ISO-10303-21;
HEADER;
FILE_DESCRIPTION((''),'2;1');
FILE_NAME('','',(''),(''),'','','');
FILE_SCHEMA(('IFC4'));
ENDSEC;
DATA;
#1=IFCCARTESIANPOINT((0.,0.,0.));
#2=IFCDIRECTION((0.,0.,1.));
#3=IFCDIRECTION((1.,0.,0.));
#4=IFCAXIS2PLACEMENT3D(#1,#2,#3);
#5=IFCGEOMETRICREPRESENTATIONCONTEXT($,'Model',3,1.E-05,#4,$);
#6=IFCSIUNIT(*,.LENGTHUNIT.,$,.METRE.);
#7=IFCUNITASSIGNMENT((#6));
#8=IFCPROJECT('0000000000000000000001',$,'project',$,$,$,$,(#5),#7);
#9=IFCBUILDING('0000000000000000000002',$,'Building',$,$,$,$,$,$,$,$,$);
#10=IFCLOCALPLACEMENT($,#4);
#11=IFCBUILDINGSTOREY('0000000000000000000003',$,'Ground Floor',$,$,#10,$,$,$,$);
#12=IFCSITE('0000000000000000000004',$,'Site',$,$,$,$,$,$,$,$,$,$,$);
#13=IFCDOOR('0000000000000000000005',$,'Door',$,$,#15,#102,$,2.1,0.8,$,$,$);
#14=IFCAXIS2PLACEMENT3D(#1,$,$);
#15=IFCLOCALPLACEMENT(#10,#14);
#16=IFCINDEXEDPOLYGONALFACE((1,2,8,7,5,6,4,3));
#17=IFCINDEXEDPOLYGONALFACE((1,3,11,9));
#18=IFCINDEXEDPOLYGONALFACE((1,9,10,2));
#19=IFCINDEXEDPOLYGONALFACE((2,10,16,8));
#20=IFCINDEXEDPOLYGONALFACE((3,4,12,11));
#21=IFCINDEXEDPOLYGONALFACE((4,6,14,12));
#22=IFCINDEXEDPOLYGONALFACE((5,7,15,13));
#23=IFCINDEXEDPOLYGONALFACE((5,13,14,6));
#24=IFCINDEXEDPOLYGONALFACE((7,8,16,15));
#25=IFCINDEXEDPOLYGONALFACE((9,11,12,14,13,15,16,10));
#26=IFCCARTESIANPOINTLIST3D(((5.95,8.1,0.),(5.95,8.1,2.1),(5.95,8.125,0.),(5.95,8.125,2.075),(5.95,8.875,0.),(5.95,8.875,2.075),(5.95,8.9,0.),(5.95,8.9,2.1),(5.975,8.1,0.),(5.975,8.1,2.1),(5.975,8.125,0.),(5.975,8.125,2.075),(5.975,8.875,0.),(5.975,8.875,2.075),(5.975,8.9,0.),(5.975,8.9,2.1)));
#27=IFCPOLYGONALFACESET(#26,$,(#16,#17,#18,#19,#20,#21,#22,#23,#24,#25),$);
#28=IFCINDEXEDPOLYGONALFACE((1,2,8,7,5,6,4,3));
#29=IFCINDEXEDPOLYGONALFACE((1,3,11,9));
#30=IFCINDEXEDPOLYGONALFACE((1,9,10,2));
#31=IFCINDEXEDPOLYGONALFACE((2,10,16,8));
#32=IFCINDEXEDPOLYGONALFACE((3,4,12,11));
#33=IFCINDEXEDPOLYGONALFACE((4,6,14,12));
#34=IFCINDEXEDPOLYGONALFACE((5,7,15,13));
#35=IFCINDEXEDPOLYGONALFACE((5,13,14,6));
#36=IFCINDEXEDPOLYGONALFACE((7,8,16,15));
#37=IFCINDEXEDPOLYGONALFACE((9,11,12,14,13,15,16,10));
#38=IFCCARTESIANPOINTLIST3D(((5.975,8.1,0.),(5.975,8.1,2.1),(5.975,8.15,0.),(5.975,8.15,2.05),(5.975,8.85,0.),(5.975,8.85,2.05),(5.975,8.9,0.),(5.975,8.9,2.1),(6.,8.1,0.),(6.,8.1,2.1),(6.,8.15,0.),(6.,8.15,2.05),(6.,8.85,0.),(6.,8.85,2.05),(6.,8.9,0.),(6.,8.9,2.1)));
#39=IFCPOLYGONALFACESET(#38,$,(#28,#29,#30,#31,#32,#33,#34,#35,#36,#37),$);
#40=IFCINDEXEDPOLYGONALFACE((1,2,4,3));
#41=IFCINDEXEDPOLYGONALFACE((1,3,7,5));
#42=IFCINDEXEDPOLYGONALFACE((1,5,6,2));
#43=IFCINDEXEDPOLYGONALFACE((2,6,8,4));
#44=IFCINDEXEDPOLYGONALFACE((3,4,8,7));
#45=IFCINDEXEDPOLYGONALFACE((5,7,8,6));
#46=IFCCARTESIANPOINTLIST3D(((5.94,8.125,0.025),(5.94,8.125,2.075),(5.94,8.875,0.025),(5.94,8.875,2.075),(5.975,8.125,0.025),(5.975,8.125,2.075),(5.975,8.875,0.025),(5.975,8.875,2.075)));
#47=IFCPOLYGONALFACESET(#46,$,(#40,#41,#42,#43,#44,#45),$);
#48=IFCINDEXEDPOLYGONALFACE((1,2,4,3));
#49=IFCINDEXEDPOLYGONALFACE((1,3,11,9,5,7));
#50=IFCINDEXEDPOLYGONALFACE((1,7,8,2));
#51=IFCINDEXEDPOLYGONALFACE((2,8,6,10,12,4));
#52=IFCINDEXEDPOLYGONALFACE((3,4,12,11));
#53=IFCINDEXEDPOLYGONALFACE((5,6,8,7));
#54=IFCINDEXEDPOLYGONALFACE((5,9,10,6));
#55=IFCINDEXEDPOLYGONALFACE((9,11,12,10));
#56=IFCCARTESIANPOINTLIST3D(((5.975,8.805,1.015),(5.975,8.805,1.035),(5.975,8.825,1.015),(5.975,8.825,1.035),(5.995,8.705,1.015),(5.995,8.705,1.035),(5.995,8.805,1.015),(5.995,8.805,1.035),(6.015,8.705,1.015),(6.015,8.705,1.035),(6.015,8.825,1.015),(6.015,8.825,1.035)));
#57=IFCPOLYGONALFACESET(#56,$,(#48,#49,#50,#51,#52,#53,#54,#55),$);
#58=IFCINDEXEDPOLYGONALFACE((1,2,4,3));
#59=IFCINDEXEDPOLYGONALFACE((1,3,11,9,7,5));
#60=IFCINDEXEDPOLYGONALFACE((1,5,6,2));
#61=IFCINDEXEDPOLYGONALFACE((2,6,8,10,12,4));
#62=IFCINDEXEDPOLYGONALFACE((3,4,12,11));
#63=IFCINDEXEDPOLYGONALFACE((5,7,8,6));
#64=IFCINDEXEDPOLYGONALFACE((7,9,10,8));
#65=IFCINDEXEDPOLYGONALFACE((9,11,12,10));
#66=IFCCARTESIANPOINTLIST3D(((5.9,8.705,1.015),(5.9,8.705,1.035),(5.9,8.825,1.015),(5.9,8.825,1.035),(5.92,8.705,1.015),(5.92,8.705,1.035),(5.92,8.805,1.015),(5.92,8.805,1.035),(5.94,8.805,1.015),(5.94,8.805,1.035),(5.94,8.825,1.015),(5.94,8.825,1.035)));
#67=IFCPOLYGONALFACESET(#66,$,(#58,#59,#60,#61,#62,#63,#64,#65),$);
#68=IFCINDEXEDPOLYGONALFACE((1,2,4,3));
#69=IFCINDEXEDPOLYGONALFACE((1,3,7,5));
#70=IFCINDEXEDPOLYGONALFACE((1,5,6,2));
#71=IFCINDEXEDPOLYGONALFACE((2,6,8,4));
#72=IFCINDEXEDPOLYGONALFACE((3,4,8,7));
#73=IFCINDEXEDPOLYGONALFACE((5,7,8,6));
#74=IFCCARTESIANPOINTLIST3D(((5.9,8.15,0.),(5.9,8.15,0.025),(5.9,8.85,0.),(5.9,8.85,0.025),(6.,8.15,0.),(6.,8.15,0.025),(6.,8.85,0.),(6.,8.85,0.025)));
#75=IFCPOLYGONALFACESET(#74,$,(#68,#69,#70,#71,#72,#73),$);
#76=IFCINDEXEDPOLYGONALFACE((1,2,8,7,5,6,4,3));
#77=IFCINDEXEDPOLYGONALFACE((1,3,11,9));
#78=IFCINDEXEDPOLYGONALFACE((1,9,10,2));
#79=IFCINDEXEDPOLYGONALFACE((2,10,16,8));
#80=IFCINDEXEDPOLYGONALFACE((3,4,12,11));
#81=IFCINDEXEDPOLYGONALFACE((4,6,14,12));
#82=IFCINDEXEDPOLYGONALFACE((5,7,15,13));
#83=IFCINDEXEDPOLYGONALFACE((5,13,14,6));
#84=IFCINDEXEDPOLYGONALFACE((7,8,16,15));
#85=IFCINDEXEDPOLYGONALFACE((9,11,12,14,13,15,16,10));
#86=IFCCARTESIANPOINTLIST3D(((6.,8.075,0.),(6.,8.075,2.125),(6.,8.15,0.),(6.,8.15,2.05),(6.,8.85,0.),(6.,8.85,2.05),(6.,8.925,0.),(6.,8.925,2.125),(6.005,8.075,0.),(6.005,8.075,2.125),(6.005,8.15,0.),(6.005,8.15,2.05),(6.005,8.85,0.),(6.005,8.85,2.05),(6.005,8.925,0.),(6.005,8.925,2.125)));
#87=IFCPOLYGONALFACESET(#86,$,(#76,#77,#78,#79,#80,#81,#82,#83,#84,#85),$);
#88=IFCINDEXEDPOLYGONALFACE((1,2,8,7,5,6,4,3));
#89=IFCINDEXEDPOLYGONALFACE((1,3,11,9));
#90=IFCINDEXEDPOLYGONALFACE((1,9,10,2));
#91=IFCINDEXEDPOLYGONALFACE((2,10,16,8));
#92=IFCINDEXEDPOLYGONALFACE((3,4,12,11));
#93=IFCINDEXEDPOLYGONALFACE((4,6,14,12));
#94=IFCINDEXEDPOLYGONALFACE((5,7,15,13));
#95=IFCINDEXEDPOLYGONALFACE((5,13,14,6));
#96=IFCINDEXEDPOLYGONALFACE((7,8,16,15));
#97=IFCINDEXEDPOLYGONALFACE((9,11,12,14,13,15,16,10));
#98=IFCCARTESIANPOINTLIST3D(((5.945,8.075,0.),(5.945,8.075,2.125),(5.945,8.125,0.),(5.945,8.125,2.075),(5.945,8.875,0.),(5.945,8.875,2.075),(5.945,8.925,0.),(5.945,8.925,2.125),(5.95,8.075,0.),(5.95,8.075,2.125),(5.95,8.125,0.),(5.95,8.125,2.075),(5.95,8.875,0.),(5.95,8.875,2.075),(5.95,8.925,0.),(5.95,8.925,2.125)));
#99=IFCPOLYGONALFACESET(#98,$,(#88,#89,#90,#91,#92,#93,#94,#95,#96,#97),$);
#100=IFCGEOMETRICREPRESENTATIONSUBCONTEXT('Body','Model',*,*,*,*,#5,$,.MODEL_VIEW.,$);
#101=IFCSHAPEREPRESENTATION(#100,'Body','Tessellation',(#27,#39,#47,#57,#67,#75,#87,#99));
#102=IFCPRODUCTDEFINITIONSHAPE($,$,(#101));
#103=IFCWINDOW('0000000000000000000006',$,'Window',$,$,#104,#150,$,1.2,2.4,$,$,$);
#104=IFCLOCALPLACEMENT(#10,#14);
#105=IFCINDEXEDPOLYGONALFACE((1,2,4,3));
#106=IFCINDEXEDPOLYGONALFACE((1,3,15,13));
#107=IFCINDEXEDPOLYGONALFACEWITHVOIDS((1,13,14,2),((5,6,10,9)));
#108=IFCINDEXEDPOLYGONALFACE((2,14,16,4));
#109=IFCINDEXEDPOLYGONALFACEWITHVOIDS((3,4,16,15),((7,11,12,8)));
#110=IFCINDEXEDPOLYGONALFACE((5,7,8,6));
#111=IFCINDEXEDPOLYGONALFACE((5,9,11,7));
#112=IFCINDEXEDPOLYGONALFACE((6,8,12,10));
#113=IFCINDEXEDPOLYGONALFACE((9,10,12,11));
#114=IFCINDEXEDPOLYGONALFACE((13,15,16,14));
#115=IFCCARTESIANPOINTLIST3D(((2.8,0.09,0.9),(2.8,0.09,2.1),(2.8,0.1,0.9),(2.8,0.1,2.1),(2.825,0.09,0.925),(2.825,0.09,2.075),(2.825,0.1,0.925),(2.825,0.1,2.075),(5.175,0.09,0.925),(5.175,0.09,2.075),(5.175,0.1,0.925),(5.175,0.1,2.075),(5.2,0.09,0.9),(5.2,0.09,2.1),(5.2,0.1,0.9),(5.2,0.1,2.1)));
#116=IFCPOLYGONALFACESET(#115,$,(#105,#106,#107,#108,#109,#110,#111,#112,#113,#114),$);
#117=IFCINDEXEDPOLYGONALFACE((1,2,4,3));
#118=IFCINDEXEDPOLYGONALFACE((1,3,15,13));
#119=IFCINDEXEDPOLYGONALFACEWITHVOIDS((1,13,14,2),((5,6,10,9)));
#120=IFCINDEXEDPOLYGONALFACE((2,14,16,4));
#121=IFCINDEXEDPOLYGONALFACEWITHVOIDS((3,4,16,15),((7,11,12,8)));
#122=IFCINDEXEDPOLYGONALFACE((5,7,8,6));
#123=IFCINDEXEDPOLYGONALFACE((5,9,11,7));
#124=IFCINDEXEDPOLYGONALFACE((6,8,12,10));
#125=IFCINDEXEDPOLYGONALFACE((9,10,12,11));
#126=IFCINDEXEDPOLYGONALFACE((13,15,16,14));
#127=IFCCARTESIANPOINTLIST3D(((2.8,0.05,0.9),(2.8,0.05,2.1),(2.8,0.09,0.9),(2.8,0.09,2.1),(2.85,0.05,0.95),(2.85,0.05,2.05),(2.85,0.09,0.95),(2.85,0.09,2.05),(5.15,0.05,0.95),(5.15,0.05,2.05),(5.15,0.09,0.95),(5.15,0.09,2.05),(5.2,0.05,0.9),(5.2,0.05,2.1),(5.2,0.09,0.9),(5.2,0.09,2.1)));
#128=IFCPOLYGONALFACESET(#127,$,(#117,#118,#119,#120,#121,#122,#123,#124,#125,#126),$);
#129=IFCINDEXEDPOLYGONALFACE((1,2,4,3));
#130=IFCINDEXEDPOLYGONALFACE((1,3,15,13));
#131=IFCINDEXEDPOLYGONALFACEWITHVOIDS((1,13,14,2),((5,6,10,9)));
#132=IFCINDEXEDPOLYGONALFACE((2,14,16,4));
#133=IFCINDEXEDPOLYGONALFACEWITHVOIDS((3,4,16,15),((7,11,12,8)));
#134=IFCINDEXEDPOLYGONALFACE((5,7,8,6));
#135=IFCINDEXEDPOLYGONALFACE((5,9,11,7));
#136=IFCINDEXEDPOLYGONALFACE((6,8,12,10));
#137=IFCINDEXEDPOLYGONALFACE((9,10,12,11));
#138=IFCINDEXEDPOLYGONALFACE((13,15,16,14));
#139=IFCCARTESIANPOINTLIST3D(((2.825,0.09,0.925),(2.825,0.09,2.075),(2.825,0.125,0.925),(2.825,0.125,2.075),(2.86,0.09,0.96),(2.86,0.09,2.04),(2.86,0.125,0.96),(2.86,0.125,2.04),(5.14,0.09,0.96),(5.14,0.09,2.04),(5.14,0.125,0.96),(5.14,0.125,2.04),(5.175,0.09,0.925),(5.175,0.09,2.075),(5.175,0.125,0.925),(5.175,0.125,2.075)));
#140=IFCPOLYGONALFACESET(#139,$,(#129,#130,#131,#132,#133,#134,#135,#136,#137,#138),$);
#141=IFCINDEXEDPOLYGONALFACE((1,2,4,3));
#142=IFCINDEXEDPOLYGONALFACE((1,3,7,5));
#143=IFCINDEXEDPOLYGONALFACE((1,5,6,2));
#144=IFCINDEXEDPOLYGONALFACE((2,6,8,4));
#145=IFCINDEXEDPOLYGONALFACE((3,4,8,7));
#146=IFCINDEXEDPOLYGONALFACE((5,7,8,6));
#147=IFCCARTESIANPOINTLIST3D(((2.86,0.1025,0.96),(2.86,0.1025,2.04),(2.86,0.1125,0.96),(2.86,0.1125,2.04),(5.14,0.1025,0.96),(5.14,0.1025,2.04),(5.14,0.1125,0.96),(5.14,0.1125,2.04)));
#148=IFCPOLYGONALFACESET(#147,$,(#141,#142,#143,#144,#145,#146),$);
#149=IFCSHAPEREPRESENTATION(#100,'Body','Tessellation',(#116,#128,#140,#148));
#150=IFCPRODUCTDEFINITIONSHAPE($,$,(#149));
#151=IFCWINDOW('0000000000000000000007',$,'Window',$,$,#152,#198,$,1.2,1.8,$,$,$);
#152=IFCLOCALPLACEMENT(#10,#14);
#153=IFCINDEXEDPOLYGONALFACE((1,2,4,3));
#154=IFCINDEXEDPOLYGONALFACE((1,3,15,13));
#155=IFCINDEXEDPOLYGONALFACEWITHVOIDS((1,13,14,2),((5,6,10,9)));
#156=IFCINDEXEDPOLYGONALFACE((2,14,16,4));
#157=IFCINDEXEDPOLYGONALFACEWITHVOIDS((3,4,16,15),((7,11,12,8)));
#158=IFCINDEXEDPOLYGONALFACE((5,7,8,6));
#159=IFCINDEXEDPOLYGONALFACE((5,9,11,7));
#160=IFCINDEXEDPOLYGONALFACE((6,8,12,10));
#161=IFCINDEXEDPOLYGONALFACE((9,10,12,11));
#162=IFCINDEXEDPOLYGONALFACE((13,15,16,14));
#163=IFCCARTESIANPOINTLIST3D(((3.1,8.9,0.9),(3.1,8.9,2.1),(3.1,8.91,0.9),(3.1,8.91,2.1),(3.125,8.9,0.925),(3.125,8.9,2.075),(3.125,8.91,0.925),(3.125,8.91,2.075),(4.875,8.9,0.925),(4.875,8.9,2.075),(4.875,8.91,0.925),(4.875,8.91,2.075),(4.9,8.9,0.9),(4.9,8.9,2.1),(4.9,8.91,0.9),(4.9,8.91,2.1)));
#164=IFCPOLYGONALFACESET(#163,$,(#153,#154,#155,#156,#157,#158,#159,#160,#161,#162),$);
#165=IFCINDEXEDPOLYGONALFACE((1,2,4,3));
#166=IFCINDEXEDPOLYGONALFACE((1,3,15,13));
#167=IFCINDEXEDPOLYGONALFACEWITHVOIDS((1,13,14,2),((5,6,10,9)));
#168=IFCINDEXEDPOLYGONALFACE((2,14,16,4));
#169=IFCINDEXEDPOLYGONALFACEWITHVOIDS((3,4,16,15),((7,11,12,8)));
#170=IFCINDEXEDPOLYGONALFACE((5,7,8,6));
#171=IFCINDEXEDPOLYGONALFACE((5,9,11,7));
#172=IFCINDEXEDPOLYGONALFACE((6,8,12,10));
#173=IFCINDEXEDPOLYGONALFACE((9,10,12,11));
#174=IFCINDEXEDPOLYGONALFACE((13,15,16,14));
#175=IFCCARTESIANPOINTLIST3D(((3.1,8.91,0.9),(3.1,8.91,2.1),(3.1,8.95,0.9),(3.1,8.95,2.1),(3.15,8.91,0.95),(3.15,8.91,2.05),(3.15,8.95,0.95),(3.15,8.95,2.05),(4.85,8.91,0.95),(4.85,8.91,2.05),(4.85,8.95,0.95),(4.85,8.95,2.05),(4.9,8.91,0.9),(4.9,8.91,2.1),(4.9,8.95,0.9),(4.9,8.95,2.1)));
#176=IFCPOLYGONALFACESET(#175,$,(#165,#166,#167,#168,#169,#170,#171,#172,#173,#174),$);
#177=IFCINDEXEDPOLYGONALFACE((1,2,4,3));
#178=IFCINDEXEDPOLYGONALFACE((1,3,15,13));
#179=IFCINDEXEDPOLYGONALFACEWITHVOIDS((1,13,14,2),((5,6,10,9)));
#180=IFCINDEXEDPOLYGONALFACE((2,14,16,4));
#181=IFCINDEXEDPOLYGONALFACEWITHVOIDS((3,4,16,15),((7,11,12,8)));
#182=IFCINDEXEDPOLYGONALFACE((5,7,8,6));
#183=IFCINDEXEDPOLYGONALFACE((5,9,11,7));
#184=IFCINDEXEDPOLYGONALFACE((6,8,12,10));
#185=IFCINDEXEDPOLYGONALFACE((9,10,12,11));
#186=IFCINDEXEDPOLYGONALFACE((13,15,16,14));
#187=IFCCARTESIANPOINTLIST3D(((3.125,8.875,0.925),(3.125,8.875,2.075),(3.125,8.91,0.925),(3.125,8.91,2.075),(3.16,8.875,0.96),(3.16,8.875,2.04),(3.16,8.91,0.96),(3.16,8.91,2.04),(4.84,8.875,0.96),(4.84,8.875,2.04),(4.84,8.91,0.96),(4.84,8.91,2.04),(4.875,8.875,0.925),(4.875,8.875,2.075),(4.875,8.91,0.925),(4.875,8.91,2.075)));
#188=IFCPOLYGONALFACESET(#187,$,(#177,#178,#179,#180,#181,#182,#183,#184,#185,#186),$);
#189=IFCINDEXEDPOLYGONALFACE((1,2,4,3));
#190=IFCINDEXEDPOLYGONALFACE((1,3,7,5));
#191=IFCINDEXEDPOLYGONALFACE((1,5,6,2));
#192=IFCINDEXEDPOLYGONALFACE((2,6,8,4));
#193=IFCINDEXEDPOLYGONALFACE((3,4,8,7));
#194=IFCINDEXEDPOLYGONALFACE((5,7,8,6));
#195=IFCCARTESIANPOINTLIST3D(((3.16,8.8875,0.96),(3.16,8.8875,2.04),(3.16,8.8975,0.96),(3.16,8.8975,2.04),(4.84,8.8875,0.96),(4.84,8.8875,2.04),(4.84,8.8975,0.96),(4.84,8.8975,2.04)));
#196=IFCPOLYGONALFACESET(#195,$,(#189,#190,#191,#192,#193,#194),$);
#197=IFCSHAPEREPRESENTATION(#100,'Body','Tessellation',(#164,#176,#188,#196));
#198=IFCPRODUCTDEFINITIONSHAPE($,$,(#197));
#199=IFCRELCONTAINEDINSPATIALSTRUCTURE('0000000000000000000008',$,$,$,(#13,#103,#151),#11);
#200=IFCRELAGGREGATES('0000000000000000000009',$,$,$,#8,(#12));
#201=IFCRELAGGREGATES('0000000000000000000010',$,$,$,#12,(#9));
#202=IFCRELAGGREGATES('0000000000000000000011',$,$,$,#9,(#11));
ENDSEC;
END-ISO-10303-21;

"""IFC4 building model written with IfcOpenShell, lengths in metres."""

from ifc_helpers import new_model, si_unit, frame, origin_with_axes, place, context, subcontext, project, spatial, line, indexed_curve, outline, extrude, element, save


model = new_model("IFC4")

# Units and contexts
model_context = context("Model", 3, precision=1e-05, world=origin_with_axes())
body_context = subcontext(model_context, "Body", "Model", "MODEL_VIEW")
ifc_project = project(units=[si_unit("LENGTHUNIT", "METRE")], contexts=[model_context])

# Site, building, storey
site = spatial("IfcSite", under=ifc_project, Name="Site")
building = spatial("IfcBuilding", under=site, Name="Building")
storey_placement = place(None, origin_with_axes())
storey = spatial("IfcBuildingStorey", under=building, at=storey_placement, Name="Ground Floor")

# Door
door_1_placement = place(storey_placement, frame((6.0, 8.1, 0.0), z_axis=(0.0, 0.0, 1.0), x_axis=(0.0, 1.0, 0.0)))
element("IfcDoor", 1, at=door_1_placement, inside=storey, Name="Door", OverallHeight=2.1, OverallWidth=0.8, context=body_context, shape_type="SweptSolid", body=[
    extrude(outline(indexed_curve([(0.0, 0.0), (0.0, 2.1), (0.8, 2.1), (0.8, 0.0), (0.775, 0.0), (0.775, 2.075), (0.025, 2.075), (0.025, 0.0)], segments=[line(1, 2, 3, 4, 5, 6, 7, 8, 1)])), frame((0.0, 0.025, 0.0), z_axis=(0.0, -1.0, 0.0), x_axis=(1.0, 0.0, 0.0)), (0.0, 0.0, -1.0), 0.025),
    extrude(outline(indexed_curve([(0.0, 0.0), (0.0, 2.1), (0.8, 2.1), (0.8, 0.0), (0.75, 0.0), (0.75, 2.05), (0.05, 2.05), (0.05, 0.0)], segments=[line(1, 2, 3, 4, 5, 6, 7, 8, 1)])), frame((0.0, 0.0, 0.0), z_axis=(0.0, -1.0, 0.0), x_axis=(1.0, 0.0, 0.0)), (0.0, 0.0, -1.0), 0.025),
    extrude(outline(indexed_curve([(0.0, 0.0), (0.75, 0.0), (0.75, 0.035), (0.0, 0.035)], segments=[line(1, 2, 3, 4, 1)])), frame((0.025, 0.025, 0.025), z_axis=(0.0, 0.0, 1.0), x_axis=(1.0, 0.0, 0.0)), (0.0, 0.0, 1.0), 2.05),
    extrude(outline(indexed_curve([(0.0, 0.0), (0.0, -0.04), (-0.12, -0.04), (-0.12, -0.02), (-0.02, -0.02), (-0.02, 0.0)], segments=[line(1, 2, 3, 4, 5, 6, 1)])), frame((0.725, 0.025, 1.015), z_axis=(0.0, 0.0, 1.0), x_axis=(1.0, 0.0, 0.0)), (0.0, 0.0, 1.0), 0.02),
    extrude(outline(indexed_curve([(0.0, 0.0), (0.0, 0.04), (-0.12, 0.04), (-0.12, 0.02), (-0.02, 0.02), (-0.02, 0.0)], segments=[line(1, 2, 3, 4, 5, 6, 1)])), frame((0.725, 0.06, 1.015), z_axis=(0.0, 0.0, 1.0), x_axis=(1.0, 0.0, 0.0)), (0.0, 0.0, 1.0), 0.02),
    extrude(outline(indexed_curve([(0.0, 0.0), (0.7, 0.0), (0.7, 0.1), (0.0, 0.1)], segments=[line(1, 2, 3, 4, 1)])), frame((0.05, 0.0, 0.0), z_axis=(0.0, 0.0, 1.0), x_axis=(1.0, 0.0, 0.0)), (0.0, 0.0, 1.0), 0.025),
    extrude(outline(indexed_curve([(0.0, 0.0), (0.0, 2.125), (0.85, 2.125), (0.85, 0.0), (0.775, 0.0), (0.775, 2.05), (0.075, 2.05), (0.075, 0.0)], segments=[line(1, 2, 3, 4, 5, 6, 7, 8, 1)])), frame((-0.025, -0.005, 0.0), z_axis=(0.0, -1.0, 0.0), x_axis=(1.0, 0.0, 0.0)), (0.0, 0.0, -1.0), 0.005),
    extrude(outline(indexed_curve([(0.0, 0.0), (0.0, 2.125), (0.85, 2.125), (0.85, 0.0), (0.8, 0.0), (0.8, 2.075), (0.05, 2.075), (0.05, 0.0)], segments=[line(1, 2, 3, 4, 5, 6, 7, 8, 1)])), frame((-0.025, 0.05, 0.0), z_axis=(0.0, -1.0, 0.0), x_axis=(1.0, 0.0, 0.0)), (0.0, 0.0, -1.0), 0.005),
])

# Windows
window_1_placement = place(storey_placement, frame((2.8, 0.0, 0.9), z_axis=(0.0, 0.0, 1.0), x_axis=(1.0, 0.0, 0.0)))
element("IfcWindow", 2, at=window_1_placement, inside=storey, Name="Window", OverallHeight=1.2, OverallWidth=2.4, context=body_context, shape_type="SweptSolid", body=[
    extrude(outline(indexed_curve([(0.0, 0.0), (2.4, 0.0), (2.4, 1.2), (0.0, 1.2)], segments=[line(1, 2, 3, 4, 1)]), holes=[indexed_curve([(0.025, 0.025), (2.375, 0.025), (2.375, 1.175), (0.025, 1.175)], segments=[line(1, 2, 3, 4, 1)])]), frame((0.0, 0.09, 0.0), z_axis=(0.0, -1.0, 0.0), x_axis=(1.0, 0.0, 0.0)), (0.0, 0.0, -1.0), 0.01),
    extrude(outline(indexed_curve([(0.0, 0.0), (2.4, 0.0), (2.4, 1.2), (0.0, 1.2)], segments=[line(1, 2, 3, 4, 1)]), holes=[indexed_curve([(0.05, 0.05), (2.35, 0.05), (2.35, 1.15), (0.05, 1.15)], segments=[line(1, 2, 3, 4, 1)])]), frame((0.0, 0.05, 0.0), z_axis=(0.0, -1.0, 0.0), x_axis=(1.0, 0.0, 0.0)), (0.0, 0.0, -1.0), 0.04),
    extrude(outline(indexed_curve([(0.0, 0.0), (2.35, 0.0), (2.35, 1.15), (0.0, 1.15)], segments=[line(1, 2, 3, 4, 1)]), holes=[indexed_curve([(0.035, 0.035), (2.315, 0.035), (2.315, 1.115), (0.035, 1.115)], segments=[line(1, 2, 3, 4, 1)])]), frame((0.025, 0.09, 0.025), z_axis=(0.0, -1.0, 0.0), x_axis=(1.0, 0.0, 0.0)), (0.0, 0.0, -1.0), 0.035),
    extrude(outline(indexed_curve([(0.035, 0.035), (2.315, 0.035), (2.315, 1.115), (0.035, 1.115)], segments=[line(1, 2, 3, 4, 1)])), frame((0.025, 0.1025, 0.025), z_axis=(0.0, -1.0, 0.0), x_axis=(1.0, 0.0, 0.0)), (0.0, 0.0, -1.0), 0.01),
])
window_2_placement = place(storey_placement, frame((4.9, 9.0, 0.9), z_axis=(0.0, 0.0, 1.0), x_axis=(-1.0, 0.0, 0.0)))
element("IfcWindow", 3, at=window_2_placement, inside=storey, Name="Window", OverallHeight=1.2, OverallWidth=1.8, context=body_context, shape_type="SweptSolid", body=[
    extrude(outline(indexed_curve([(0.0, 0.0), (1.8, 0.0), (1.8, 1.2), (0.0, 1.2)], segments=[line(1, 2, 3, 4, 1)]), holes=[indexed_curve([(0.025, 0.025), (1.775, 0.025), (1.775, 1.175), (0.025, 1.175)], segments=[line(1, 2, 3, 4, 1)])]), frame((0.0, 0.09, 0.0), z_axis=(0.0, -1.0, 0.0), x_axis=(1.0, 0.0, 0.0)), (0.0, 0.0, -1.0), 0.01),
    extrude(outline(indexed_curve([(0.0, 0.0), (1.8, 0.0), (1.8, 1.2), (0.0, 1.2)], segments=[line(1, 2, 3, 4, 1)]), holes=[indexed_curve([(0.05, 0.05), (1.75, 0.05), (1.75, 1.15), (0.05, 1.15)], segments=[line(1, 2, 3, 4, 1)])]), frame((0.0, 0.05, 0.0), z_axis=(0.0, -1.0, 0.0), x_axis=(1.0, 0.0, 0.0)), (0.0, 0.0, -1.0), 0.04),
    extrude(outline(indexed_curve([(0.0, 0.0), (1.75, 0.0), (1.75, 1.15), (0.0, 1.15)], segments=[line(1, 2, 3, 4, 1)]), holes=[indexed_curve([(0.035, 0.035), (1.715, 0.035), (1.715, 1.115), (0.035, 1.115)], segments=[line(1, 2, 3, 4, 1)])]), frame((0.025, 0.09, 0.025), z_axis=(0.0, -1.0, 0.0), x_axis=(1.0, 0.0, 0.0)), (0.0, 0.0, -1.0), 0.035),
    extrude(outline(indexed_curve([(0.035, 0.035), (1.715, 0.035), (1.715, 1.115), (0.035, 1.115)], segments=[line(1, 2, 3, 4, 1)])), frame((0.025, 0.1025, 0.025), z_axis=(0.0, -1.0, 0.0), x_axis=(1.0, 0.0, 0.0)), (0.0, 0.0, -1.0), 0.01),
])

save(model, "model.ifc")
